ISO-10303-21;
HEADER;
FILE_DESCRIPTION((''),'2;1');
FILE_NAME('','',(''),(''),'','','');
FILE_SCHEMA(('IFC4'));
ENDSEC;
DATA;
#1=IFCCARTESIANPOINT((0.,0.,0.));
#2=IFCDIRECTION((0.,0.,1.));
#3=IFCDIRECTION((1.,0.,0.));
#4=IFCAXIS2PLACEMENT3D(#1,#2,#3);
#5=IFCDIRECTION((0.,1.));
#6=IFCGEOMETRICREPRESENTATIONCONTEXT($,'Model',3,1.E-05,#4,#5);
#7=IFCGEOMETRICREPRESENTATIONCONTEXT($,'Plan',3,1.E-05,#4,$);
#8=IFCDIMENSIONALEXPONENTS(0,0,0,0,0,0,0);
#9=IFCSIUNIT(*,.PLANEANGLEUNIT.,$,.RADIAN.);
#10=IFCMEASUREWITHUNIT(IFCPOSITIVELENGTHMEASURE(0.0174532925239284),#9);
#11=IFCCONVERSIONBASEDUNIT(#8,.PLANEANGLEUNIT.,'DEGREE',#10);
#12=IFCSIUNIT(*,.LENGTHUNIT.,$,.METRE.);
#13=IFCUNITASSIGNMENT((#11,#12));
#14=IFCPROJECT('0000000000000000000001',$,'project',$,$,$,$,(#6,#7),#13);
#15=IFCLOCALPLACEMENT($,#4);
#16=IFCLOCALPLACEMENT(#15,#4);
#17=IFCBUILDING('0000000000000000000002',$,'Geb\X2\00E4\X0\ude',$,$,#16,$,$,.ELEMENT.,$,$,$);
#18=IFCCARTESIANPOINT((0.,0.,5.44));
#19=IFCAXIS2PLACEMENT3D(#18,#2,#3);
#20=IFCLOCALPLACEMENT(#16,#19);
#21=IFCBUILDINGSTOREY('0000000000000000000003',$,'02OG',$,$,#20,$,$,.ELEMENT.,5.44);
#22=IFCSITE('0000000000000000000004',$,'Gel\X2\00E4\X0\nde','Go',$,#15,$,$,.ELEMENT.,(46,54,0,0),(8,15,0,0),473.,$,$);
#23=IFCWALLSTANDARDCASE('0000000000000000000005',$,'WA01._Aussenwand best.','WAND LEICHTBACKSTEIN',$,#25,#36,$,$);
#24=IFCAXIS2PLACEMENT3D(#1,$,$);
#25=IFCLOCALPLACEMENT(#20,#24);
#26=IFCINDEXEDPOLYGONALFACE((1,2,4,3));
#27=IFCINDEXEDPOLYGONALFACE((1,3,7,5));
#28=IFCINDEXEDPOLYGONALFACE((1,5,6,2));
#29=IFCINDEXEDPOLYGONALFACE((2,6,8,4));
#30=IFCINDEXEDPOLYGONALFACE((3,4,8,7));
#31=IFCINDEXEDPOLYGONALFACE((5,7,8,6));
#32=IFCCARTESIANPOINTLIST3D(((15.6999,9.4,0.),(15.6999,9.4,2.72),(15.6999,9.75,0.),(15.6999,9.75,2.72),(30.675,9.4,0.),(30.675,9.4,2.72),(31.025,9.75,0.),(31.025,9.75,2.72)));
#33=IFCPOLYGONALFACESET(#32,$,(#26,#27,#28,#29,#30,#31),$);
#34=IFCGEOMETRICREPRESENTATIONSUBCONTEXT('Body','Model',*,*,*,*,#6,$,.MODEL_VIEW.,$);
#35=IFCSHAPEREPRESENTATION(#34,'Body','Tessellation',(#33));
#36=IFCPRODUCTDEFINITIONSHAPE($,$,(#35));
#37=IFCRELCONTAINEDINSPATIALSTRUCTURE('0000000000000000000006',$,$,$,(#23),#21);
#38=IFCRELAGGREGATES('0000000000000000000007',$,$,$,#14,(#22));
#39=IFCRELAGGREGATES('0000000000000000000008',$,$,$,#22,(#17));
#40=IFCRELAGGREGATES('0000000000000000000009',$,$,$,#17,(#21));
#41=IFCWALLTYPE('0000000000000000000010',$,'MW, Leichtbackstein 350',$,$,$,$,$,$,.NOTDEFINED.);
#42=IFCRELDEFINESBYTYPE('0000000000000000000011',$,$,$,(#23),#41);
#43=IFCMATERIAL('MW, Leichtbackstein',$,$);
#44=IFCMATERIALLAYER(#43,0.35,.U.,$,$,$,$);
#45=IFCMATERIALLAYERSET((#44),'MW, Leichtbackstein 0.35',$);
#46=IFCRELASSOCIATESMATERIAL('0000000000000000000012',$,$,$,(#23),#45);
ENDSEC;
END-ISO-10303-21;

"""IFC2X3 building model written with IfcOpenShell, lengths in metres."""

from ifc_helpers import new_model, entity, si_unit, converted_unit, direction, frame, origin_with_axes, place, context, subcontext, project, spatial, polyline, outline, extrude, material, layer, layer_set, layer_usage, type_object, element, save


model = new_model("IFC2X3")

# Units and contexts
model_context = context("Model", 3, precision=1e-05, world=origin_with_axes(), true_north=direction((0.0, 1.0)))
plan_context = context("Plan", 3, precision=1e-05, world=origin_with_axes())
body_context = subcontext(model_context, "Body", "Model", "MODEL_VIEW")
ifc_project = project(units=[converted_unit("PLANEANGLEUNIT", "DEGREE", entity("IfcPositiveLengthMeasure", 0.0174532925239284), si_unit("PLANEANGLEUNIT", "RADIAN"), dimensions=[0, 0, 0, 0, 0, 0, 0]), si_unit("LENGTHUNIT", "METRE")], contexts=[model_context, plan_context])

# Site, building, storey
site_placement = place(None, origin_with_axes())
site = spatial("IfcSite", under=ifc_project, at=site_placement, Name="Gelände", Description="Go", CompositionType="ELEMENT", RefLatitude=(46, 54, 0, 0), RefLongitude=(8, 15, 0, 0), RefElevation=473.0)
building_placement = place(site_placement, origin_with_axes())
building = spatial("IfcBuilding", under=site, at=building_placement, Name="Gebäude", CompositionType="ELEMENT")
storey_placement = place(building_placement, frame((0.0, 0.0, 5.44), z_axis=(0.0, 0.0, 1.0), x_axis=(1.0, 0.0, 0.0)))
storey = spatial("IfcBuildingStorey", under=building, at=storey_placement, Name="02OG", CompositionType="ELEMENT", Elevation=5.44)

# Wall
ifc_material_1 = material(Name="MW, Leichtbackstein")
ifc_layer_1 = layer(ifc_material_1, 0.35, ventilated="UNKNOWN")
ifc_layer_set_1 = layer_set([ifc_layer_1], Name="MW, Leichtbackstein 0.35")
ifc_layer_usage_1 = layer_usage(ifc_layer_set_1, "AXIS2", "NEGATIVE", 0.35)
wall_type_1 = type_object("IfcWallType", Name="MW, Leichtbackstein 350", PredefinedType="NOTDEFINED")
wall_1_placement = place(storey_placement, frame((15.6999, 9.4, 0.0), z_axis=(0.0, 0.0, 1.0), x_axis=(1.0, 0.0, 0.0)))
element("IfcWallStandardCase", 1, at=wall_1_placement, inside=storey, type_object=wall_type_1, material=ifc_layer_usage_1, Name="WA01._Aussenwand best.", Description="WAND LEICHTBACKSTEIN", context=body_context, shape_type="SweptSolid", body=[
    extrude(outline(polyline([(0.0, 0.0), (14.9751, 0.0), (15.3251, 0.35), (0.0, 0.35), (0.0, 0.0)])), origin_with_axes(), (0.0, 0.0, 1.0), 2.72),
])

save(model, "model.ifc")
